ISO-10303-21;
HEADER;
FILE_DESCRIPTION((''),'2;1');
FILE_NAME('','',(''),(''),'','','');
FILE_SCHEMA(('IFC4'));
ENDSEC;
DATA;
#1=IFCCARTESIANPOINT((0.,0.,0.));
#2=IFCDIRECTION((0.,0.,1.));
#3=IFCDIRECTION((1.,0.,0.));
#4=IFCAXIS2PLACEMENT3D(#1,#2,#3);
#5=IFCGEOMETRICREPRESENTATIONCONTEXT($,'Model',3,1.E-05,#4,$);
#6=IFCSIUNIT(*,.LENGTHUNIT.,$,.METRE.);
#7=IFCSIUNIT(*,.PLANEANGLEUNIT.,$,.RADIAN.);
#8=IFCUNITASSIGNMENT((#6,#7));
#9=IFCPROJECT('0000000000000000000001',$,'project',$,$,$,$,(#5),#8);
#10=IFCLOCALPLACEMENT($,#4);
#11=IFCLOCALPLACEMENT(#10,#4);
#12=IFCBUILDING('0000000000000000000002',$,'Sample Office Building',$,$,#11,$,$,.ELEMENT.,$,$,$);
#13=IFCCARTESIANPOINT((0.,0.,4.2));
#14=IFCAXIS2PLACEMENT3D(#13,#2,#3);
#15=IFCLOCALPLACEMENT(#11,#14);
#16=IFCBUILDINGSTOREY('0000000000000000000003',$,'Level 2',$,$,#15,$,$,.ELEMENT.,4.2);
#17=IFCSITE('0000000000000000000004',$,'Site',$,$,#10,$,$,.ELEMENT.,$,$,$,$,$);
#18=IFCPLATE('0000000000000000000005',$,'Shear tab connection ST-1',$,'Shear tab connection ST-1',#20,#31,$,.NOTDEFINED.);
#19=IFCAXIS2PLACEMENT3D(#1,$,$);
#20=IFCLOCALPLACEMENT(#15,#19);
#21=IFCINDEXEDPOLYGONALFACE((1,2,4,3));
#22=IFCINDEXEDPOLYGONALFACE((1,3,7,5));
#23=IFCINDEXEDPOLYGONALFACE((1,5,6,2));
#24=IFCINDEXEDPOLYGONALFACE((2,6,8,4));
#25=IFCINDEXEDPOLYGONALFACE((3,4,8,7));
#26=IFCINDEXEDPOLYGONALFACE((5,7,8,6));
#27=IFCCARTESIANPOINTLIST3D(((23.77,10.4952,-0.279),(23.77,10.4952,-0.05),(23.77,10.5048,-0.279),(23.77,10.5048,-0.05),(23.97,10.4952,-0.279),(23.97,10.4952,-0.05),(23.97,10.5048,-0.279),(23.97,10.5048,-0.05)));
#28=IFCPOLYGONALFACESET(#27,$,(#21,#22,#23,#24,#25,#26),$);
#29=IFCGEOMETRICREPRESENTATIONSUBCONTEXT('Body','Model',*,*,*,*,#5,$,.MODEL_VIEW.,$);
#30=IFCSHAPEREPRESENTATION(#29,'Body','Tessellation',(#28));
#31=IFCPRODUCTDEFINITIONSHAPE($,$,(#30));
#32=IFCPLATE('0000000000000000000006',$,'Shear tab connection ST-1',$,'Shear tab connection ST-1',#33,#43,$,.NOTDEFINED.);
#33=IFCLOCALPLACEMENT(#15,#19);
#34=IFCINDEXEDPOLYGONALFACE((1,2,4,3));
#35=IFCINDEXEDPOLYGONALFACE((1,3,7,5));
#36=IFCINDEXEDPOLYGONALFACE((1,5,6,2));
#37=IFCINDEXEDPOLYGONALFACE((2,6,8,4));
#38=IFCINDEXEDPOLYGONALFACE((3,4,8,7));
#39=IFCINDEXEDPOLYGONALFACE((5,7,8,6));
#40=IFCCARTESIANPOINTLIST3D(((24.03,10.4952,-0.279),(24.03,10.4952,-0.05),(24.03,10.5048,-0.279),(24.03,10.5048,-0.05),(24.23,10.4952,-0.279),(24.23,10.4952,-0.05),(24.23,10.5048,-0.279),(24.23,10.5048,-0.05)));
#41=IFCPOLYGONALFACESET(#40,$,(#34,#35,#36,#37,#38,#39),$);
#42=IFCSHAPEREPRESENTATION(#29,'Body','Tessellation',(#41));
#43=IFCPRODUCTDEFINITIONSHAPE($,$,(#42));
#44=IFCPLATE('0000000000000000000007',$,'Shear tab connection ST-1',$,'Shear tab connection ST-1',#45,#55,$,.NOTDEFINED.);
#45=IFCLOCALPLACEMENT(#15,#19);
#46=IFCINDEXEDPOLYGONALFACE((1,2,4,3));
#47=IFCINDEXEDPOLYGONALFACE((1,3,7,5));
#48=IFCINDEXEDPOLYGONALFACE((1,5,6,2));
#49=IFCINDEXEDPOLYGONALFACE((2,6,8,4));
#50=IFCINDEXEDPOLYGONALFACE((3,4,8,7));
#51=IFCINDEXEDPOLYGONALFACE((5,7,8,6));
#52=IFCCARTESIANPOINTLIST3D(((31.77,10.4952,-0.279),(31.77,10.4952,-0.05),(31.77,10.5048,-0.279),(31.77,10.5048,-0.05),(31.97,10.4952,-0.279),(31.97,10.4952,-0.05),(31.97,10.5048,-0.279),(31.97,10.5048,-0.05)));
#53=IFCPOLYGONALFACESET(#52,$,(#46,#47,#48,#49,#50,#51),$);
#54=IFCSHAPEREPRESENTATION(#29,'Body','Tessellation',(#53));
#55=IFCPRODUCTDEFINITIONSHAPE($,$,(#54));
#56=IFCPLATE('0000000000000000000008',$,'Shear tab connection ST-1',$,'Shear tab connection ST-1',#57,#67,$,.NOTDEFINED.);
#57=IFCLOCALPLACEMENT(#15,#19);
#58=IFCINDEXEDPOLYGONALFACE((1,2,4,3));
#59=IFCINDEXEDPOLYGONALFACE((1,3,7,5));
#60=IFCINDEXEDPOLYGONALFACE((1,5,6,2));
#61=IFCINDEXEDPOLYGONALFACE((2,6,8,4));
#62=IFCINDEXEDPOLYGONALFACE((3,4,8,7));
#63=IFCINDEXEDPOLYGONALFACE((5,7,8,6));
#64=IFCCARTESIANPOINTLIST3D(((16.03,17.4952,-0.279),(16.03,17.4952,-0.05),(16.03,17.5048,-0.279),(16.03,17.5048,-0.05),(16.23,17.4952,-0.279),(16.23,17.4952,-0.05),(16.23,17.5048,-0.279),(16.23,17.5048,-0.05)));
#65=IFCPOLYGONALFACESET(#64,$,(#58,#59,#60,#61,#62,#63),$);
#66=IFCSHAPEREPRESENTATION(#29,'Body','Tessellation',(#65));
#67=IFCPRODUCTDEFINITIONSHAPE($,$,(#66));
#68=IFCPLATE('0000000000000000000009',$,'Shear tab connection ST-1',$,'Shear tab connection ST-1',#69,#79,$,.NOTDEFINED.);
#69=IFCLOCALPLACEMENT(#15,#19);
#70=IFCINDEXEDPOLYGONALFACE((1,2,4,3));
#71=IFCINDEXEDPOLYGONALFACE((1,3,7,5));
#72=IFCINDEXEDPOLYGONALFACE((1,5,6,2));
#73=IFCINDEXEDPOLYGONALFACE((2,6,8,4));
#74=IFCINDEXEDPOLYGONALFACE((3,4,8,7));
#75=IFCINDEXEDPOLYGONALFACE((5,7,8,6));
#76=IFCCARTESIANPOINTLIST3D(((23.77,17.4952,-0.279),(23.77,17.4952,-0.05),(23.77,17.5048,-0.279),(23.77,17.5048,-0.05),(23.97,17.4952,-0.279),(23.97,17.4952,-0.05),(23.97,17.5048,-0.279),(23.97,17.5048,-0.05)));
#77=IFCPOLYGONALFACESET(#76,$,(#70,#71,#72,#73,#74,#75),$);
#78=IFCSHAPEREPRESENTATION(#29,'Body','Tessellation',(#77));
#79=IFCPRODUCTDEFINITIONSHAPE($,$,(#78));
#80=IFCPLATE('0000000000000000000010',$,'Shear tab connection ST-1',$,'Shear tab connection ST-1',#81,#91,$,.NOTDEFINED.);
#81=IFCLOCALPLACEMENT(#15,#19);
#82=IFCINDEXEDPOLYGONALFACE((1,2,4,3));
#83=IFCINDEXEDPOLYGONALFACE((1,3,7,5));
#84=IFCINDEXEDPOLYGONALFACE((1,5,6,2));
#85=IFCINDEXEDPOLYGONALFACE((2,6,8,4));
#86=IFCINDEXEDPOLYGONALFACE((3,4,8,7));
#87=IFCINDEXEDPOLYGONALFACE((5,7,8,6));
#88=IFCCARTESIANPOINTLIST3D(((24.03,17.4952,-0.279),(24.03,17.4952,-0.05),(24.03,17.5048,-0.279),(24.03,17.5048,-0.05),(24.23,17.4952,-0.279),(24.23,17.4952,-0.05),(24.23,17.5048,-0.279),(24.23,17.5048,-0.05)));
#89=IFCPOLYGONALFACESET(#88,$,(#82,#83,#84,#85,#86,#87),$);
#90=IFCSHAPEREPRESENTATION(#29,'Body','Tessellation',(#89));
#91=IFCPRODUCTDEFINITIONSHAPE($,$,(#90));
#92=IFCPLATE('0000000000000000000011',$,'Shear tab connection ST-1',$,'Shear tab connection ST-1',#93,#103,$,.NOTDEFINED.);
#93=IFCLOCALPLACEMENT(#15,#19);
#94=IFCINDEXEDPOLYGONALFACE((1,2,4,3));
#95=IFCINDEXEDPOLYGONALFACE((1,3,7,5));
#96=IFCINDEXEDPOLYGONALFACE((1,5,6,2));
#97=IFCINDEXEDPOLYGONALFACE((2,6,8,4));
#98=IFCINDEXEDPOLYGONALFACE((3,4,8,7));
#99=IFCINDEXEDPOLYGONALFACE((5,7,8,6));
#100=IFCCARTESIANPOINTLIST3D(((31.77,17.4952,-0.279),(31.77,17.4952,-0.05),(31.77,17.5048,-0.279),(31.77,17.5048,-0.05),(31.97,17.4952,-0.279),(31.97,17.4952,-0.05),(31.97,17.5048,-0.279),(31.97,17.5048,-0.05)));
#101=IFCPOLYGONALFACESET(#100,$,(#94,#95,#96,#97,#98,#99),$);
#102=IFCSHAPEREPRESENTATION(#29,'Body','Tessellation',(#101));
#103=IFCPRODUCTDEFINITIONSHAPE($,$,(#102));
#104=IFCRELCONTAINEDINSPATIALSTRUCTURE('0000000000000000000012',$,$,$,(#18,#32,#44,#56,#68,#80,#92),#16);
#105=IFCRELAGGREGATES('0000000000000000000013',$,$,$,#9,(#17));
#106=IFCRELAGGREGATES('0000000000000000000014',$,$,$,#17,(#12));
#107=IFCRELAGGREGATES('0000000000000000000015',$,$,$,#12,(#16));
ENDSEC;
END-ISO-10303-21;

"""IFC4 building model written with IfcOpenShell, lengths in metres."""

from ifc_helpers import new_model, si_unit, frame, origin_with_axes, place, context, subcontext, project, spatial, rectangle, extrude, element, save


model = new_model("IFC4")

# Units and contexts
model_context = context("Model", 3, precision=1e-05, world=origin_with_axes())
body_context = subcontext(model_context, "Body", "Model", "MODEL_VIEW")
ifc_project = project(units=[si_unit("LENGTHUNIT", "METRE"), si_unit("PLANEANGLEUNIT", "RADIAN")], contexts=[model_context])

# Site, building, storey
site_placement = place(None, origin_with_axes())
site = spatial("IfcSite", under=ifc_project, at=site_placement, Name="Site", CompositionType="ELEMENT")
building_placement = place(site_placement, origin_with_axes())
building = spatial("IfcBuilding", under=site, at=building_placement, Name="Sample Office Building", CompositionType="ELEMENT")
storey_placement = place(building_placement, frame((0.0, 0.0, 4.2), z_axis=(0.0, 0.0, 1.0), x_axis=(1.0, 0.0, 0.0)))
storey = spatial("IfcBuildingStorey", under=building, at=storey_placement, Name="Level 2", CompositionType="ELEMENT", Elevation=4.2)

# Plates
for number, where, z_axis, x_axis, name in (
    (1, (23.87, 10.5, 3.921), (0.0, 0.0, 1.0), (1.0, 0.0, 0.0), "Shear tab connection ST-1"),
    (2, (24.13, 10.5, 3.921), (0.0, 0.0, 1.0), (1.0, 0.0, 0.0), "Shear tab connection ST-1"),
    (3, (31.87, 10.5, 3.921), (0.0, 0.0, 1.0), (1.0, 0.0, 0.0), "Shear tab connection ST-1"),
):
    element("IfcPlate", number, at=place(None, frame(where, z_axis=z_axis, x_axis=x_axis)), inside=storey, Name=name, ObjectType="Shear tab connection ST-1", PredefinedType="NOTDEFINED", context=body_context, shape_type="SweptSolid", body=[
        extrude(rectangle(XDim=0.2, YDim=0.0095), None, (0.0, 0.0, 1.0), 0.229),
    ])
for number, where, z_axis, x_axis, name in (
    (4, (16.13, 17.5, 3.921), (0.0, 0.0, 1.0), (1.0, 0.0, 0.0), "Shear tab connection ST-1"),
    (5, (23.87, 17.5, 3.921), (0.0, 0.0, 1.0), (1.0, 0.0, 0.0), "Shear tab connection ST-1"),
    (6, (24.13, 17.5, 3.921), (0.0, 0.0, 1.0), (1.0, 0.0, 0.0), "Shear tab connection ST-1"),
    (7, (31.87, 17.5, 3.921), (0.0, 0.0, 1.0), (1.0, 0.0, 0.0), "Shear tab connection ST-1"),
):
    element("IfcPlate", number, at=place(None, frame(where, z_axis=z_axis, x_axis=x_axis)), inside=storey, Name=name, ObjectType="Shear tab connection ST-1", PredefinedType="NOTDEFINED", context=body_context, shape_type="SweptSolid", body=[
        extrude(rectangle(XDim=0.2, YDim=0.0095), None, (0.0, 0.0, 1.0), 0.229),
    ])

save(model, "model.ifc")
